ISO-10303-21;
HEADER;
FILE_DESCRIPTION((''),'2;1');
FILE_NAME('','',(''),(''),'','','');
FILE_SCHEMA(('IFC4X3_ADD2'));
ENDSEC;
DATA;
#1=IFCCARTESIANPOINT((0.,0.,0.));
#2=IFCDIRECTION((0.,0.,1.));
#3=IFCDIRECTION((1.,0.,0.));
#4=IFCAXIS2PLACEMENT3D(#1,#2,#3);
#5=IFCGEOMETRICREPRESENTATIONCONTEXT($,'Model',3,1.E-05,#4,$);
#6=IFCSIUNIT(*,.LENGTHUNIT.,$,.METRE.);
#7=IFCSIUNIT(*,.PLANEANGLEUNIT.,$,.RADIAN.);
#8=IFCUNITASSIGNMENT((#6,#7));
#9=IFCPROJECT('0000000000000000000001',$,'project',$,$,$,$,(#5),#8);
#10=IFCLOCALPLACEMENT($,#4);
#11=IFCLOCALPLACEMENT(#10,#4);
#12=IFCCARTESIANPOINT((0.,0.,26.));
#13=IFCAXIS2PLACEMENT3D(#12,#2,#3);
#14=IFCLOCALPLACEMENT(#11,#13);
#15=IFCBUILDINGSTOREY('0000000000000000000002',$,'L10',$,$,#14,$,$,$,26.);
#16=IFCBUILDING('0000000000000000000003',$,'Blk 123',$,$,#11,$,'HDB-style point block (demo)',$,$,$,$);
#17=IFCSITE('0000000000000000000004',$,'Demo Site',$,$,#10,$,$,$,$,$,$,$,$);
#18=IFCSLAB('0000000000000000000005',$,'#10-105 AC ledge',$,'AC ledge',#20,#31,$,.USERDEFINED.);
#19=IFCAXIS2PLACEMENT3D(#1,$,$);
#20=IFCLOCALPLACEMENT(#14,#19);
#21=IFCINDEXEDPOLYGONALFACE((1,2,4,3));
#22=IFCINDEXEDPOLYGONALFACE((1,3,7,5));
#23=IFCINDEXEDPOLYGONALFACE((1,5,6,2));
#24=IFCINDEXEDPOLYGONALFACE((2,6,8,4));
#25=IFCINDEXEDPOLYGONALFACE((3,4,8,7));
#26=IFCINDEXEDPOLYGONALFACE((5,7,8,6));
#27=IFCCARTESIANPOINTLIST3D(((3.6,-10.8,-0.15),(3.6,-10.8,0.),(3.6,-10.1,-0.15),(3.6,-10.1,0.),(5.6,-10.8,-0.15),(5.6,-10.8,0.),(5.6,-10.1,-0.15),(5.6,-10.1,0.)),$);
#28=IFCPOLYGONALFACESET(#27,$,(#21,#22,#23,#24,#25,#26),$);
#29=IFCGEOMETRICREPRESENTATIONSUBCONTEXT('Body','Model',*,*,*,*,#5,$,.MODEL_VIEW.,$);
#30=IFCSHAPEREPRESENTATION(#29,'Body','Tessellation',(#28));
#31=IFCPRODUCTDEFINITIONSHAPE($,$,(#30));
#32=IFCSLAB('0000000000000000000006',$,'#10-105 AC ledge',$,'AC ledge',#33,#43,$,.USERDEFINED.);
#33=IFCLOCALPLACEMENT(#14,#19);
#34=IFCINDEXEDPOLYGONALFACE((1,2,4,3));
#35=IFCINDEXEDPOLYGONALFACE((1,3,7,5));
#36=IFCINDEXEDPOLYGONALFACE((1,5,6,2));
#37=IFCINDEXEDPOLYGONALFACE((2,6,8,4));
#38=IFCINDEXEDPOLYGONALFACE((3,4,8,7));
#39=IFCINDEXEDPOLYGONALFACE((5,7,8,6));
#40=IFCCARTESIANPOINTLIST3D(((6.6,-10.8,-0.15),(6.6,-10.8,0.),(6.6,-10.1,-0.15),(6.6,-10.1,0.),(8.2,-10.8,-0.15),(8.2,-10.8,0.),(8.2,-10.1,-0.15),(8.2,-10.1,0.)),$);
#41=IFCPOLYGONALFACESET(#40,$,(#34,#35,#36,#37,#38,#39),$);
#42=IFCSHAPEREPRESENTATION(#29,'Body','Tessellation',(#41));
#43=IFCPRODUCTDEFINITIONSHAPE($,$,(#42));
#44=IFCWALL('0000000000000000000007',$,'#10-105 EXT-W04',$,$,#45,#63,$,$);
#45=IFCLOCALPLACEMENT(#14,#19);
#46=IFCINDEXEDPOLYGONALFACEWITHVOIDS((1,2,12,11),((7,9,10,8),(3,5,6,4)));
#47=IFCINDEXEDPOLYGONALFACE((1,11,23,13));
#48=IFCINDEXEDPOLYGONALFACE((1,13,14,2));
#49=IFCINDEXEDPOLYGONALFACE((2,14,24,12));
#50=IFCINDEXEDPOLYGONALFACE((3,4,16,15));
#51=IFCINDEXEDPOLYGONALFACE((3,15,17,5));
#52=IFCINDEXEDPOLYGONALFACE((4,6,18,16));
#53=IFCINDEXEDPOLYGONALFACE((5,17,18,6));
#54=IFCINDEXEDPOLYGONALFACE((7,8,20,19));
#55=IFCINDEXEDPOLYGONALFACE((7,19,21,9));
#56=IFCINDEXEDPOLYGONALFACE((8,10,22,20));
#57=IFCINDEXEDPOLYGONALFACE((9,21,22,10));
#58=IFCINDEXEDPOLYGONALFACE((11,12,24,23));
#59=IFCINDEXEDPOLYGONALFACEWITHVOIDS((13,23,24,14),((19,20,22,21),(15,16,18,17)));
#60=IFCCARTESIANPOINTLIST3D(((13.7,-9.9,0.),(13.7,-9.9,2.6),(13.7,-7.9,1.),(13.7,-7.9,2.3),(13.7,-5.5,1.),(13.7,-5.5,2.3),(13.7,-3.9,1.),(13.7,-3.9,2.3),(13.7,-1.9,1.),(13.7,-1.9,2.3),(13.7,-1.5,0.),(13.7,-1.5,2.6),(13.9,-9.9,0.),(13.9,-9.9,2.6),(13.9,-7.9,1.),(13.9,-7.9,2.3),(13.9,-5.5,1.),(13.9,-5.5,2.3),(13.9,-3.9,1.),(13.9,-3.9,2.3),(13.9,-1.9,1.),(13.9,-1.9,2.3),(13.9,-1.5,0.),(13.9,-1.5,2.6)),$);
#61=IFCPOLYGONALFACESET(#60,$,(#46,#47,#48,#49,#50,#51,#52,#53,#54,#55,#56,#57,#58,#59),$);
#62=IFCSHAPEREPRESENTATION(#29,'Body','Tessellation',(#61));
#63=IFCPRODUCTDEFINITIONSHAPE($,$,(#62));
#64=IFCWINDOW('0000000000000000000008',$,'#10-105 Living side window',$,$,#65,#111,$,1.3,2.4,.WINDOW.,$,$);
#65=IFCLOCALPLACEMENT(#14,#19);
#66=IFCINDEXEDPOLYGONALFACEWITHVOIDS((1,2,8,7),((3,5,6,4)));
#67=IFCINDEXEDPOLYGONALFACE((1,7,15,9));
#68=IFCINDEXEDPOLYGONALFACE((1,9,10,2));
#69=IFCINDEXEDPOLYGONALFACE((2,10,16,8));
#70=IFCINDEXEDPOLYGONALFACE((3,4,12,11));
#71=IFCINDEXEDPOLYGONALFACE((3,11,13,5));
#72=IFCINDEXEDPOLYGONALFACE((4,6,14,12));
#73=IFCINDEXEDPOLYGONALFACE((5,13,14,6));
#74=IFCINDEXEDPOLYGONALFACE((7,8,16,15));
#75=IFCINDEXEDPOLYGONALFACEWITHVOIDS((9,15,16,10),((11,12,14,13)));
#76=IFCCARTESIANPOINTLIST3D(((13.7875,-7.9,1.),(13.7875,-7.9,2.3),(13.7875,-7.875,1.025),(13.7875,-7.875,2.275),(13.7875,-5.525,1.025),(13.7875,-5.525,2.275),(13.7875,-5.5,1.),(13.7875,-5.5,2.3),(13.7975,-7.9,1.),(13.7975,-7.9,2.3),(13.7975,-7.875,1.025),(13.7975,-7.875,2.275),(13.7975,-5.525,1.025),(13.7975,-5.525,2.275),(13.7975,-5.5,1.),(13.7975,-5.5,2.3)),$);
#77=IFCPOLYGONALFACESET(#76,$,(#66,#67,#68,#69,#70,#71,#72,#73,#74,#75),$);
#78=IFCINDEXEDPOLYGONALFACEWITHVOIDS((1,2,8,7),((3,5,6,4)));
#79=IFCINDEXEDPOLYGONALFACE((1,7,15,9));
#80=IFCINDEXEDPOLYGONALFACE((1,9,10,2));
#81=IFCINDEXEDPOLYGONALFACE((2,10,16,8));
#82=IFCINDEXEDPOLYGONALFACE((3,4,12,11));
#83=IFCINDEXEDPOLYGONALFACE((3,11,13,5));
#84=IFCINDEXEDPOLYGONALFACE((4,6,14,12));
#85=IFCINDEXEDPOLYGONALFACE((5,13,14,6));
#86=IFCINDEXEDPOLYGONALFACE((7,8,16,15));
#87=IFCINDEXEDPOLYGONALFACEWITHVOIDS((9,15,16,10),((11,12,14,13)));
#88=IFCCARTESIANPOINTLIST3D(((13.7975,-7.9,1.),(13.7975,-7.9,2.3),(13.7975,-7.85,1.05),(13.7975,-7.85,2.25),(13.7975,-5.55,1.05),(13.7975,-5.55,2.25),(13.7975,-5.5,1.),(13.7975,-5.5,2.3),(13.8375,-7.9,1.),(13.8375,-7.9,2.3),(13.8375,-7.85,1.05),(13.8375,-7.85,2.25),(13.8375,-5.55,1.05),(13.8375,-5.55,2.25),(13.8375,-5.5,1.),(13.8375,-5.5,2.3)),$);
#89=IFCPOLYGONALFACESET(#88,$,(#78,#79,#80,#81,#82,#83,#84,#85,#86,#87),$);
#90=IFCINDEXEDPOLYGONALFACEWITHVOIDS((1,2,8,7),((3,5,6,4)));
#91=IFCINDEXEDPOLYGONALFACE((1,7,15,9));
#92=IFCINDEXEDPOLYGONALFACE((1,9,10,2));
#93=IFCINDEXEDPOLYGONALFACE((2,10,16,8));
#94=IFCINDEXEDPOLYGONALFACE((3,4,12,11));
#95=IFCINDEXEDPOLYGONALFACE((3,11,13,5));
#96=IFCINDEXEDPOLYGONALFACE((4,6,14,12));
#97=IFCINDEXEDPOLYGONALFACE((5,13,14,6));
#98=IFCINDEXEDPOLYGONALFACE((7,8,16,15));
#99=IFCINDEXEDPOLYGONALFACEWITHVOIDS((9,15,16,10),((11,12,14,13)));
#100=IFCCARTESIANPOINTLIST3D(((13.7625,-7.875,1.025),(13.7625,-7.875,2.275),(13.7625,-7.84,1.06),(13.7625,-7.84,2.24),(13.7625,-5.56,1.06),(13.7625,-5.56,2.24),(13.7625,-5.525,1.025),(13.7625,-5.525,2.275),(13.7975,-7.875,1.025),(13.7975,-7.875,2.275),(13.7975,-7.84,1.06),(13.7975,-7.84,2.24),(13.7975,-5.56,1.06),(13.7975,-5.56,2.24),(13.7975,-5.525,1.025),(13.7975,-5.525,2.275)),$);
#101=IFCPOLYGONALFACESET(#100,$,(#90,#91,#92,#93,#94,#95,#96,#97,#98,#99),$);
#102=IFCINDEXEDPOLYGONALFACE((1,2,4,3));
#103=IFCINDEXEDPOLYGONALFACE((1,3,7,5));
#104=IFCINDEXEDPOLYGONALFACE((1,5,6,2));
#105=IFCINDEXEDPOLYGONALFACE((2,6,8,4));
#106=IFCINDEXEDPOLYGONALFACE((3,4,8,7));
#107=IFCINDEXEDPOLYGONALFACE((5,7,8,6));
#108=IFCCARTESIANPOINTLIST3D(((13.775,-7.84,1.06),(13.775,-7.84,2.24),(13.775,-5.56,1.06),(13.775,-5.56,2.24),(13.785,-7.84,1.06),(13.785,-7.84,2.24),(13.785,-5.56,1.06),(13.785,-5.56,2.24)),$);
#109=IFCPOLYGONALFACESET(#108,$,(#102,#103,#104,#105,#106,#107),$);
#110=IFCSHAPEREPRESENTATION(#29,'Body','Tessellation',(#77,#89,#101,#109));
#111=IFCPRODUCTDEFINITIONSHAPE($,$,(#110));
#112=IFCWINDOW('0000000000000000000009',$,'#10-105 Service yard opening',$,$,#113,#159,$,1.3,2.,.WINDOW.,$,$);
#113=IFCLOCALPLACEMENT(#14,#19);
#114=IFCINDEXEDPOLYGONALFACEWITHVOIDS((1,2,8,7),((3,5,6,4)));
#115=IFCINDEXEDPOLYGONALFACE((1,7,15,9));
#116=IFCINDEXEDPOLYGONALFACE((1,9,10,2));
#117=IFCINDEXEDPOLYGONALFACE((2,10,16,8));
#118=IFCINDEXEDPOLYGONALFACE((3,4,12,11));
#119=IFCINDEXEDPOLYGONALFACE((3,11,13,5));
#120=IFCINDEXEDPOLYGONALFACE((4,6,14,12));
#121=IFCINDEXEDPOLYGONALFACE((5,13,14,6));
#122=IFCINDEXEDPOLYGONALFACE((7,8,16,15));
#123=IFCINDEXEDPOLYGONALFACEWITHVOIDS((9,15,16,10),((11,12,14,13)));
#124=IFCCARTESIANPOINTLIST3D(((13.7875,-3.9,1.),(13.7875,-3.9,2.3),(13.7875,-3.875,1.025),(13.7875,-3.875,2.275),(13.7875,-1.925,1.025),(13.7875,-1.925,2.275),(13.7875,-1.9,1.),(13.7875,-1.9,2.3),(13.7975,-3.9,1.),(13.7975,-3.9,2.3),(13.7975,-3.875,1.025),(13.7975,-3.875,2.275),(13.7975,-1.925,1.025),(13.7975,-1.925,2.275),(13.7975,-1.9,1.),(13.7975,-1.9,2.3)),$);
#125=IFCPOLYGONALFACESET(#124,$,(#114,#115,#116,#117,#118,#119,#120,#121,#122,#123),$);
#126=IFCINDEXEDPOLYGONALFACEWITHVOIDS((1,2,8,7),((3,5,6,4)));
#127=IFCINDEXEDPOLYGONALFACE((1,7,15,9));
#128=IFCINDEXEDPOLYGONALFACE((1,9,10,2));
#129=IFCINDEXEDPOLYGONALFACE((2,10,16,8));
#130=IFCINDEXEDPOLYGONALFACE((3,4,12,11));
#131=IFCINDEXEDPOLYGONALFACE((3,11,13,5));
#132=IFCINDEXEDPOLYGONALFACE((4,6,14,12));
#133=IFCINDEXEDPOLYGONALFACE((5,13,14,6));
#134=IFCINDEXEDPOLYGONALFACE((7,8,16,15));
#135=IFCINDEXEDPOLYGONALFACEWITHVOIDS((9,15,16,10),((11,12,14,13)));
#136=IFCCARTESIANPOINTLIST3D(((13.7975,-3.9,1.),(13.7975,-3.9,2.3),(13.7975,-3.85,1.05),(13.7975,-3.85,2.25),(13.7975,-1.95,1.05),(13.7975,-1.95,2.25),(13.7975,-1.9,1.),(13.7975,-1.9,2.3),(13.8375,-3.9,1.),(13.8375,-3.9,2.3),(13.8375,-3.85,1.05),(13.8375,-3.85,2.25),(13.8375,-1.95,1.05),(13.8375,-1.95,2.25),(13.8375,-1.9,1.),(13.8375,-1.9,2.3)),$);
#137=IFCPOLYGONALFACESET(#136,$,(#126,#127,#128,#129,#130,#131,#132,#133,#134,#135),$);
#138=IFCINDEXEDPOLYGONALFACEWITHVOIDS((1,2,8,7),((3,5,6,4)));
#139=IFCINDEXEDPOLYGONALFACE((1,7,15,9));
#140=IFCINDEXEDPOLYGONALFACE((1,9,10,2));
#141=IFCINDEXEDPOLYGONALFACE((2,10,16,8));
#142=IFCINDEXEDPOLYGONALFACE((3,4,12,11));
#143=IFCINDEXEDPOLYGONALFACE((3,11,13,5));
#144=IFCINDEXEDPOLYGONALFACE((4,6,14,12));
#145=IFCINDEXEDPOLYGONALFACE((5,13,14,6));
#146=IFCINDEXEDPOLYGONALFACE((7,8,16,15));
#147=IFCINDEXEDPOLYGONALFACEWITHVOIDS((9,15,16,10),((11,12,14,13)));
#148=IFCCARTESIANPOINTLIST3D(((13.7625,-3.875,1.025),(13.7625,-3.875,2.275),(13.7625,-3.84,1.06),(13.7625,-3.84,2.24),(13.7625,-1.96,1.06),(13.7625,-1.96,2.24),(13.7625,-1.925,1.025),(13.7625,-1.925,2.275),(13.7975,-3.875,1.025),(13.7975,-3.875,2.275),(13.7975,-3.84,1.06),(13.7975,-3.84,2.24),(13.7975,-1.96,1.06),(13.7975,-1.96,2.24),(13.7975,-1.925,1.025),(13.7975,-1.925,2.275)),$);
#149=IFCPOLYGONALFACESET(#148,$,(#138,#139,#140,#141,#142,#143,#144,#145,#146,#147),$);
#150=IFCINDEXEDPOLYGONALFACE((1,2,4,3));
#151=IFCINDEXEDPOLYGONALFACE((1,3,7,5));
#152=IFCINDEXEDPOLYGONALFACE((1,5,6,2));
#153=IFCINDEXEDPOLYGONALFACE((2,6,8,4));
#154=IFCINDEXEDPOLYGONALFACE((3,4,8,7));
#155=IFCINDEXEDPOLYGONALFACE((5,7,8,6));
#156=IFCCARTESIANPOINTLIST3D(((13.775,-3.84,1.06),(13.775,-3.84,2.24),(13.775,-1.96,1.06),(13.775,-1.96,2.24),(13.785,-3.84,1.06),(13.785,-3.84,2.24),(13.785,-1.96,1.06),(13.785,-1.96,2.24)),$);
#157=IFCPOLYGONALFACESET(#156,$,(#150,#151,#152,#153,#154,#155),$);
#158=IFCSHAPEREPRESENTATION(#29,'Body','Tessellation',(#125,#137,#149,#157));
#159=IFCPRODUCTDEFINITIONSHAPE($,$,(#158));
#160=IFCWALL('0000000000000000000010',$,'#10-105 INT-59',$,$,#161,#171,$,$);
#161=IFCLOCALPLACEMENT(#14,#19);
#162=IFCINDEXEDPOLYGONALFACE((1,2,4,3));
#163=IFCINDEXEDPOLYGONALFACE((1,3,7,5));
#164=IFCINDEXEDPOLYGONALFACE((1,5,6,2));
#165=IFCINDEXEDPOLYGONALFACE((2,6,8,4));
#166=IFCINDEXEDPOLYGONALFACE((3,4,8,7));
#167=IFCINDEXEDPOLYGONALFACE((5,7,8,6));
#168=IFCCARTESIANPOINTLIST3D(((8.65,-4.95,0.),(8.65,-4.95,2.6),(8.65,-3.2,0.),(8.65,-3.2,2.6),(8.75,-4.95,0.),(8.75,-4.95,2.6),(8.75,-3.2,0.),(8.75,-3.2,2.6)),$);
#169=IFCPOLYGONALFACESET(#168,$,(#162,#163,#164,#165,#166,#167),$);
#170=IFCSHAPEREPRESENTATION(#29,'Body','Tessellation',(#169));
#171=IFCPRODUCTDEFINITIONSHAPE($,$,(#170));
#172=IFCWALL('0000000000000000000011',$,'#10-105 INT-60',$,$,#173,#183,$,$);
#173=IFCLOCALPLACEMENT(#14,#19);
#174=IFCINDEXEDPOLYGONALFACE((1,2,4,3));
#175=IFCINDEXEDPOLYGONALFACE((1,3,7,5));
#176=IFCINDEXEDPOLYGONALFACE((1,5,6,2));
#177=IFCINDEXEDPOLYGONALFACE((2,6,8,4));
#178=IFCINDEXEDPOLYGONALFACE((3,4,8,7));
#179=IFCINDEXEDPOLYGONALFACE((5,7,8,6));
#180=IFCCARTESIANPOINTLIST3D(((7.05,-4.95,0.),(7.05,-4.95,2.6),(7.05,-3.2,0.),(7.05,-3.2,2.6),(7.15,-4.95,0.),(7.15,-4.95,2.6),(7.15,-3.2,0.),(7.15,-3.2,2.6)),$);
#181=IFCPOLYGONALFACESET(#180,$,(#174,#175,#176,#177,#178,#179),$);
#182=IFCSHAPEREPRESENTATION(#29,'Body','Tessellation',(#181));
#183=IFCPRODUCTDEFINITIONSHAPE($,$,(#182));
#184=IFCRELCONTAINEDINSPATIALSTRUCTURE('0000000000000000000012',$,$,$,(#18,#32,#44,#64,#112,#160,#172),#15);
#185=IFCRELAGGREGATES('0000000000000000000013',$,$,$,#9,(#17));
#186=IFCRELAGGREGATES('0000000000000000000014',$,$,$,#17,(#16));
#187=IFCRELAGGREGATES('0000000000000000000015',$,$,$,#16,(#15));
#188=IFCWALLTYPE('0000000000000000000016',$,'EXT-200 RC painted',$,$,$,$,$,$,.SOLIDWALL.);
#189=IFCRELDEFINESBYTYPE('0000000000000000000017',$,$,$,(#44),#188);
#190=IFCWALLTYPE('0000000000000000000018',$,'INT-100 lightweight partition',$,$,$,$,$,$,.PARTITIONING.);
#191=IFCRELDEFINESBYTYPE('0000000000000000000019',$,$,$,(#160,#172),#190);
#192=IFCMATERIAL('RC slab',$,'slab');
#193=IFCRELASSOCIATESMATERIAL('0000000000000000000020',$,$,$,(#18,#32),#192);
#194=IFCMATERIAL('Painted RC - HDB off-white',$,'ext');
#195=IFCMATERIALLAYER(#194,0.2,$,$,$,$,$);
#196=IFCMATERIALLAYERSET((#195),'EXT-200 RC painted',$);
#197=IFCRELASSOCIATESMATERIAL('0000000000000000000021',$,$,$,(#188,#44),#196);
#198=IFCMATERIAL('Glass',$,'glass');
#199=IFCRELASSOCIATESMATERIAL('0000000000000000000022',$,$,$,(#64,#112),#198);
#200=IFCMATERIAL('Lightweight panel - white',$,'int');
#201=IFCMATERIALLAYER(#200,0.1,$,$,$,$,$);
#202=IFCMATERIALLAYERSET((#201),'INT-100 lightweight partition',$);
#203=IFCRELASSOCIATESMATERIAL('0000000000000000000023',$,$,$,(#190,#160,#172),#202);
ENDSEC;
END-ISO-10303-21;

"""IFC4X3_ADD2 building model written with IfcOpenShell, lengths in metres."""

from ifc_helpers import new_model, si_unit, frame, origin, origin_with_axes, place, context, subcontext, project, spatial, polyline, line, indexed_curve, outline, extrude, material, layer, layer_set, layer_usage, type_object, element, fill, save


model = new_model("IFC4X3_ADD2")

# Units and contexts
model_context = context("Model", 3, precision=1e-05, world=origin_with_axes())
body_context = subcontext(model_context, "Body", "Model", "MODEL_VIEW")
ifc_project = project(units=[si_unit("LENGTHUNIT", "METRE"), si_unit("PLANEANGLEUNIT", "RADIAN")], contexts=[model_context])

# Site, building, storey
site_placement = place(None, origin_with_axes())
site = spatial("IfcSite", under=ifc_project, at=site_placement, Name="Demo Site")
building_placement = place(site_placement, origin_with_axes())
building = spatial("IfcBuilding", under=site, at=building_placement, Name="Blk 123", LongName="HDB-style point block (demo)")
storey_placement = place(building_placement, frame((0.0, 0.0, 26.0), z_axis=(0.0, 0.0, 1.0), x_axis=(1.0, 0.0, 0.0)))
storey = spatial("IfcBuildingStorey", under=building, at=storey_placement, Name="L10", Elevation=26.0)

# Slabs
ifc_material_1 = material(Name="RC slab", Category="slab")
slab_1_placement = place(storey_placement, frame((4.6, -10.45, -0.15), z_axis=(0.0, 0.0, 1.0), x_axis=(1.0, 0.0, 0.0)))
element("IfcSlab", 1, at=slab_1_placement, inside=storey, material=ifc_material_1, Name="#10-105 AC ledge", ObjectType="AC ledge", PredefinedType="USERDEFINED", context=body_context, shape_type="SweptSolid", body=[
    extrude(outline(polyline([(1.0, 0.35), (-1.0, 0.35), (-1.0, -0.35), (1.0, -0.35), (1.0, 0.35)])), origin(), (0.0, 0.0, 1.0), 0.15),
])
slab_2_placement = place(storey_placement, frame((7.4, -10.45, -0.15), z_axis=(0.0, 0.0, 1.0), x_axis=(1.0, 0.0, 0.0)))
element("IfcSlab", 2, at=slab_2_placement, inside=storey, material=ifc_material_1, Name="#10-105 AC ledge", ObjectType="AC ledge", PredefinedType="USERDEFINED", context=body_context, shape_type="SweptSolid", body=[
    extrude(outline(polyline([(0.8, 0.35), (-0.8, 0.35), (-0.8, -0.35), (0.8, -0.35), (0.8, 0.35)])), origin(), (0.0, 0.0, 1.0), 0.15),
])

# Wall, openings, windows
ifc_material_2 = material(Name="Painted RC - HDB off-white", Category="ext")
ifc_layer_1 = layer(ifc_material_2, 0.2)
ifc_layer_set_1 = layer_set([ifc_layer_1], Name="EXT-200 RC painted")
ifc_layer_usage_1 = layer_usage(ifc_layer_set_1, "AXIS2", "POSITIVE", 0.0)
wall_type_1 = type_object("IfcWallType", Name="EXT-200 RC painted", PredefinedType="SOLIDWALL", material=ifc_layer_set_1)
wall_1_placement = place(storey_placement, frame((13.9, -9.9, 0.0), z_axis=(0.0, 0.0, 1.0), x_axis=(0.0, 1.0, 0.0)))
wall_1 = element("IfcWall", 3, at=wall_1_placement, inside=storey, type_object=wall_type_1, material=ifc_layer_usage_1, Name="#10-105 EXT-W04", context=body_context, shape_type="SweptSolid", body=[
    extrude(outline(indexed_curve([(0.0, 0.0), (0.0, 0.2), (8.4, 0.2), (8.4, 0.0), (0.0, 0.0)], self_intersect=False)), origin_with_axes(), (0.0, 0.0, 1.0), 2.6),
])
opening_1_placement = place(wall_1_placement, frame((2.0, -0.1, 1.0), z_axis=(0.0, 0.0, 1.0), x_axis=(1.0, 0.0, 0.0)))
opening_1 = element("IfcOpeningElement", 4, at=opening_1_placement, cuts=wall_1, context=body_context, shape_type="SweptSolid", body=[
    extrude(outline(indexed_curve([(0.0, 0.0), (0.0, 0.4), (2.4, 0.4), (2.4, 0.0), (0.0, 0.0)], self_intersect=False)), origin_with_axes(), (0.0, 0.0, 1.0), 1.3),
])
opening_2_placement = place(wall_1_placement, frame((6.0, -0.1, 1.0), z_axis=(0.0, 0.0, 1.0), x_axis=(1.0, 0.0, 0.0)))
opening_2 = element("IfcOpeningElement", 5, at=opening_2_placement, cuts=wall_1, context=body_context, shape_type="SweptSolid", body=[
    extrude(outline(indexed_curve([(0.0, 0.0), (0.0, 0.4), (2.0, 0.4), (2.0, 0.0), (0.0, 0.0)], self_intersect=False)), origin_with_axes(), (0.0, 0.0, 1.0), 1.3),
])
ifc_material_3 = material(Name="Glass", Category="glass")
window_1_placement = place(opening_1_placement, frame((0.0, 0.1125, 0.0), z_axis=(0.0, 0.0, 1.0), x_axis=(1.0, 0.0, 0.0)))
window_1 = element("IfcWindow", 6, at=window_1_placement, inside=storey, material=ifc_material_3, Name="#10-105 Living side window", OverallHeight=1.3, OverallWidth=2.4, PredefinedType="WINDOW", context=body_context, shape_type="SweptSolid", body=[
    extrude(outline(indexed_curve([(0.0, 0.0), (2.4, 0.0), (2.4, 1.3), (0.0, 1.3)], segments=[line(1, 2, 3, 4, 1)]), holes=[indexed_curve([(0.025, 0.025), (2.375, 0.025), (2.375, 1.275), (0.025, 1.275)], segments=[line(1, 2, 3, 4, 1)])]), frame((0.0, 0.09, 0.0), z_axis=(0.0, -1.0, 0.0), x_axis=(1.0, 0.0, 0.0)), (0.0, 0.0, -1.0), 0.01),
    extrude(outline(indexed_curve([(0.0, 0.0), (2.4, 0.0), (2.4, 1.3), (0.0, 1.3)], segments=[line(1, 2, 3, 4, 1)]), holes=[indexed_curve([(0.05, 0.05), (2.35, 0.05), (2.35, 1.25), (0.05, 1.25)], segments=[line(1, 2, 3, 4, 1)])]), frame((0.0, 0.05, 0.0), z_axis=(0.0, -1.0, 0.0), x_axis=(1.0, 0.0, 0.0)), (0.0, 0.0, -1.0), 0.04),
    extrude(outline(indexed_curve([(0.0, 0.0), (2.35, 0.0), (2.35, 1.25), (0.0, 1.25)], segments=[line(1, 2, 3, 4, 1)]), holes=[indexed_curve([(0.035, 0.035), (2.315, 0.035), (2.315, 1.215), (0.035, 1.215)], segments=[line(1, 2, 3, 4, 1)])]), frame((0.025, 0.09, 0.025), z_axis=(0.0, -1.0, 0.0), x_axis=(1.0, 0.0, 0.0)), (0.0, 0.0, -1.0), 0.035),
    extrude(outline(indexed_curve([(0.035, 0.035), (2.315, 0.035), (2.315, 1.215), (0.035, 1.215)], segments=[line(1, 2, 3, 4, 1)])), frame((0.025, 0.1025, 0.025), z_axis=(0.0, -1.0, 0.0), x_axis=(1.0, 0.0, 0.0)), (0.0, 0.0, -1.0), 0.01),
])
fill(opening_1, window_1)
window_2_placement = place(opening_2_placement, frame((0.0, 0.1125, 0.0), z_axis=(0.0, 0.0, 1.0), x_axis=(1.0, 0.0, 0.0)))
window_2 = element("IfcWindow", 7, at=window_2_placement, inside=storey, material=ifc_material_3, Name="#10-105 Service yard opening", OverallHeight=1.3, OverallWidth=2.0, PredefinedType="WINDOW", context=body_context, shape_type="SweptSolid", body=[
    extrude(outline(indexed_curve([(0.0, 0.0), (2.0, 0.0), (2.0, 1.3), (0.0, 1.3)], segments=[line(1, 2, 3, 4, 1)]), holes=[indexed_curve([(0.025, 0.025), (1.975, 0.025), (1.975, 1.275), (0.025, 1.275)], segments=[line(1, 2, 3, 4, 1)])]), frame((0.0, 0.09, 0.0), z_axis=(0.0, -1.0, 0.0), x_axis=(1.0, 0.0, 0.0)), (0.0, 0.0, -1.0), 0.01),
    extrude(outline(indexed_curve([(0.0, 0.0), (2.0, 0.0), (2.0, 1.3), (0.0, 1.3)], segments=[line(1, 2, 3, 4, 1)]), holes=[indexed_curve([(0.05, 0.05), (1.95, 0.05), (1.95, 1.25), (0.05, 1.25)], segments=[line(1, 2, 3, 4, 1)])]), frame((0.0, 0.05, 0.0), z_axis=(0.0, -1.0, 0.0), x_axis=(1.0, 0.0, 0.0)), (0.0, 0.0, -1.0), 0.04),
    extrude(outline(indexed_curve([(0.0, 0.0), (1.95, 0.0), (1.95, 1.25), (0.0, 1.25)], segments=[line(1, 2, 3, 4, 1)]), holes=[indexed_curve([(0.035, 0.035), (1.915, 0.035), (1.915, 1.215), (0.035, 1.215)], segments=[line(1, 2, 3, 4, 1)])]), frame((0.025, 0.09, 0.025), z_axis=(0.0, -1.0, 0.0), x_axis=(1.0, 0.0, 0.0)), (0.0, 0.0, -1.0), 0.035),
    extrude(outline(indexed_curve([(0.035, 0.035), (1.915, 0.035), (1.915, 1.215), (0.035, 1.215)], segments=[line(1, 2, 3, 4, 1)])), frame((0.025, 0.1025, 0.025), z_axis=(0.0, -1.0, 0.0), x_axis=(1.0, 0.0, 0.0)), (0.0, 0.0, -1.0), 0.01),
])
fill(opening_2, window_2)

# Walls
ifc_material_4 = material(Name="Lightweight panel - white", Category="int")
ifc_layer_2 = layer(ifc_material_4, 0.1)
ifc_layer_set_2 = layer_set([ifc_layer_2], Name="INT-100 lightweight partition")
ifc_layer_usage_2 = layer_usage(ifc_layer_set_2, "AXIS2", "POSITIVE", -0.05)
wall_type_2 = type_object("IfcWallType", Name="INT-100 lightweight partition", PredefinedType="PARTITIONING", material=ifc_layer_set_2)
for number, where, z_axis, x_axis, name in (
    (8, (8.7, -3.2, 0.0), (0.0, 0.0, 1.0), (0.0, -1.0, 0.0), "#10-105 INT-59"),
    (9, (7.1, -3.2, 0.0), (0.0, 0.0, 1.0), (0.0, -1.0, 0.0), "#10-105 INT-60"),
):
    element("IfcWall", number, at=place(storey_placement, frame(where, z_axis=z_axis, x_axis=x_axis)), inside=storey, type_object=wall_type_2, material=ifc_layer_usage_2, Name=name, context=body_context, shape_type="SweptSolid", body=[
        extrude(outline(indexed_curve([(0.0, 0.0), (0.0, 0.1), (1.75, 0.1), (1.75, 0.0), (0.0, 0.0)], self_intersect=False)), frame((0.0, -0.05, 0.0), z_axis=(0.0, 0.0, 1.0), x_axis=(1.0, 0.0, 0.0)), (0.0, 0.0, 1.0), 2.6),
    ])

save(model, "model.ifc")
